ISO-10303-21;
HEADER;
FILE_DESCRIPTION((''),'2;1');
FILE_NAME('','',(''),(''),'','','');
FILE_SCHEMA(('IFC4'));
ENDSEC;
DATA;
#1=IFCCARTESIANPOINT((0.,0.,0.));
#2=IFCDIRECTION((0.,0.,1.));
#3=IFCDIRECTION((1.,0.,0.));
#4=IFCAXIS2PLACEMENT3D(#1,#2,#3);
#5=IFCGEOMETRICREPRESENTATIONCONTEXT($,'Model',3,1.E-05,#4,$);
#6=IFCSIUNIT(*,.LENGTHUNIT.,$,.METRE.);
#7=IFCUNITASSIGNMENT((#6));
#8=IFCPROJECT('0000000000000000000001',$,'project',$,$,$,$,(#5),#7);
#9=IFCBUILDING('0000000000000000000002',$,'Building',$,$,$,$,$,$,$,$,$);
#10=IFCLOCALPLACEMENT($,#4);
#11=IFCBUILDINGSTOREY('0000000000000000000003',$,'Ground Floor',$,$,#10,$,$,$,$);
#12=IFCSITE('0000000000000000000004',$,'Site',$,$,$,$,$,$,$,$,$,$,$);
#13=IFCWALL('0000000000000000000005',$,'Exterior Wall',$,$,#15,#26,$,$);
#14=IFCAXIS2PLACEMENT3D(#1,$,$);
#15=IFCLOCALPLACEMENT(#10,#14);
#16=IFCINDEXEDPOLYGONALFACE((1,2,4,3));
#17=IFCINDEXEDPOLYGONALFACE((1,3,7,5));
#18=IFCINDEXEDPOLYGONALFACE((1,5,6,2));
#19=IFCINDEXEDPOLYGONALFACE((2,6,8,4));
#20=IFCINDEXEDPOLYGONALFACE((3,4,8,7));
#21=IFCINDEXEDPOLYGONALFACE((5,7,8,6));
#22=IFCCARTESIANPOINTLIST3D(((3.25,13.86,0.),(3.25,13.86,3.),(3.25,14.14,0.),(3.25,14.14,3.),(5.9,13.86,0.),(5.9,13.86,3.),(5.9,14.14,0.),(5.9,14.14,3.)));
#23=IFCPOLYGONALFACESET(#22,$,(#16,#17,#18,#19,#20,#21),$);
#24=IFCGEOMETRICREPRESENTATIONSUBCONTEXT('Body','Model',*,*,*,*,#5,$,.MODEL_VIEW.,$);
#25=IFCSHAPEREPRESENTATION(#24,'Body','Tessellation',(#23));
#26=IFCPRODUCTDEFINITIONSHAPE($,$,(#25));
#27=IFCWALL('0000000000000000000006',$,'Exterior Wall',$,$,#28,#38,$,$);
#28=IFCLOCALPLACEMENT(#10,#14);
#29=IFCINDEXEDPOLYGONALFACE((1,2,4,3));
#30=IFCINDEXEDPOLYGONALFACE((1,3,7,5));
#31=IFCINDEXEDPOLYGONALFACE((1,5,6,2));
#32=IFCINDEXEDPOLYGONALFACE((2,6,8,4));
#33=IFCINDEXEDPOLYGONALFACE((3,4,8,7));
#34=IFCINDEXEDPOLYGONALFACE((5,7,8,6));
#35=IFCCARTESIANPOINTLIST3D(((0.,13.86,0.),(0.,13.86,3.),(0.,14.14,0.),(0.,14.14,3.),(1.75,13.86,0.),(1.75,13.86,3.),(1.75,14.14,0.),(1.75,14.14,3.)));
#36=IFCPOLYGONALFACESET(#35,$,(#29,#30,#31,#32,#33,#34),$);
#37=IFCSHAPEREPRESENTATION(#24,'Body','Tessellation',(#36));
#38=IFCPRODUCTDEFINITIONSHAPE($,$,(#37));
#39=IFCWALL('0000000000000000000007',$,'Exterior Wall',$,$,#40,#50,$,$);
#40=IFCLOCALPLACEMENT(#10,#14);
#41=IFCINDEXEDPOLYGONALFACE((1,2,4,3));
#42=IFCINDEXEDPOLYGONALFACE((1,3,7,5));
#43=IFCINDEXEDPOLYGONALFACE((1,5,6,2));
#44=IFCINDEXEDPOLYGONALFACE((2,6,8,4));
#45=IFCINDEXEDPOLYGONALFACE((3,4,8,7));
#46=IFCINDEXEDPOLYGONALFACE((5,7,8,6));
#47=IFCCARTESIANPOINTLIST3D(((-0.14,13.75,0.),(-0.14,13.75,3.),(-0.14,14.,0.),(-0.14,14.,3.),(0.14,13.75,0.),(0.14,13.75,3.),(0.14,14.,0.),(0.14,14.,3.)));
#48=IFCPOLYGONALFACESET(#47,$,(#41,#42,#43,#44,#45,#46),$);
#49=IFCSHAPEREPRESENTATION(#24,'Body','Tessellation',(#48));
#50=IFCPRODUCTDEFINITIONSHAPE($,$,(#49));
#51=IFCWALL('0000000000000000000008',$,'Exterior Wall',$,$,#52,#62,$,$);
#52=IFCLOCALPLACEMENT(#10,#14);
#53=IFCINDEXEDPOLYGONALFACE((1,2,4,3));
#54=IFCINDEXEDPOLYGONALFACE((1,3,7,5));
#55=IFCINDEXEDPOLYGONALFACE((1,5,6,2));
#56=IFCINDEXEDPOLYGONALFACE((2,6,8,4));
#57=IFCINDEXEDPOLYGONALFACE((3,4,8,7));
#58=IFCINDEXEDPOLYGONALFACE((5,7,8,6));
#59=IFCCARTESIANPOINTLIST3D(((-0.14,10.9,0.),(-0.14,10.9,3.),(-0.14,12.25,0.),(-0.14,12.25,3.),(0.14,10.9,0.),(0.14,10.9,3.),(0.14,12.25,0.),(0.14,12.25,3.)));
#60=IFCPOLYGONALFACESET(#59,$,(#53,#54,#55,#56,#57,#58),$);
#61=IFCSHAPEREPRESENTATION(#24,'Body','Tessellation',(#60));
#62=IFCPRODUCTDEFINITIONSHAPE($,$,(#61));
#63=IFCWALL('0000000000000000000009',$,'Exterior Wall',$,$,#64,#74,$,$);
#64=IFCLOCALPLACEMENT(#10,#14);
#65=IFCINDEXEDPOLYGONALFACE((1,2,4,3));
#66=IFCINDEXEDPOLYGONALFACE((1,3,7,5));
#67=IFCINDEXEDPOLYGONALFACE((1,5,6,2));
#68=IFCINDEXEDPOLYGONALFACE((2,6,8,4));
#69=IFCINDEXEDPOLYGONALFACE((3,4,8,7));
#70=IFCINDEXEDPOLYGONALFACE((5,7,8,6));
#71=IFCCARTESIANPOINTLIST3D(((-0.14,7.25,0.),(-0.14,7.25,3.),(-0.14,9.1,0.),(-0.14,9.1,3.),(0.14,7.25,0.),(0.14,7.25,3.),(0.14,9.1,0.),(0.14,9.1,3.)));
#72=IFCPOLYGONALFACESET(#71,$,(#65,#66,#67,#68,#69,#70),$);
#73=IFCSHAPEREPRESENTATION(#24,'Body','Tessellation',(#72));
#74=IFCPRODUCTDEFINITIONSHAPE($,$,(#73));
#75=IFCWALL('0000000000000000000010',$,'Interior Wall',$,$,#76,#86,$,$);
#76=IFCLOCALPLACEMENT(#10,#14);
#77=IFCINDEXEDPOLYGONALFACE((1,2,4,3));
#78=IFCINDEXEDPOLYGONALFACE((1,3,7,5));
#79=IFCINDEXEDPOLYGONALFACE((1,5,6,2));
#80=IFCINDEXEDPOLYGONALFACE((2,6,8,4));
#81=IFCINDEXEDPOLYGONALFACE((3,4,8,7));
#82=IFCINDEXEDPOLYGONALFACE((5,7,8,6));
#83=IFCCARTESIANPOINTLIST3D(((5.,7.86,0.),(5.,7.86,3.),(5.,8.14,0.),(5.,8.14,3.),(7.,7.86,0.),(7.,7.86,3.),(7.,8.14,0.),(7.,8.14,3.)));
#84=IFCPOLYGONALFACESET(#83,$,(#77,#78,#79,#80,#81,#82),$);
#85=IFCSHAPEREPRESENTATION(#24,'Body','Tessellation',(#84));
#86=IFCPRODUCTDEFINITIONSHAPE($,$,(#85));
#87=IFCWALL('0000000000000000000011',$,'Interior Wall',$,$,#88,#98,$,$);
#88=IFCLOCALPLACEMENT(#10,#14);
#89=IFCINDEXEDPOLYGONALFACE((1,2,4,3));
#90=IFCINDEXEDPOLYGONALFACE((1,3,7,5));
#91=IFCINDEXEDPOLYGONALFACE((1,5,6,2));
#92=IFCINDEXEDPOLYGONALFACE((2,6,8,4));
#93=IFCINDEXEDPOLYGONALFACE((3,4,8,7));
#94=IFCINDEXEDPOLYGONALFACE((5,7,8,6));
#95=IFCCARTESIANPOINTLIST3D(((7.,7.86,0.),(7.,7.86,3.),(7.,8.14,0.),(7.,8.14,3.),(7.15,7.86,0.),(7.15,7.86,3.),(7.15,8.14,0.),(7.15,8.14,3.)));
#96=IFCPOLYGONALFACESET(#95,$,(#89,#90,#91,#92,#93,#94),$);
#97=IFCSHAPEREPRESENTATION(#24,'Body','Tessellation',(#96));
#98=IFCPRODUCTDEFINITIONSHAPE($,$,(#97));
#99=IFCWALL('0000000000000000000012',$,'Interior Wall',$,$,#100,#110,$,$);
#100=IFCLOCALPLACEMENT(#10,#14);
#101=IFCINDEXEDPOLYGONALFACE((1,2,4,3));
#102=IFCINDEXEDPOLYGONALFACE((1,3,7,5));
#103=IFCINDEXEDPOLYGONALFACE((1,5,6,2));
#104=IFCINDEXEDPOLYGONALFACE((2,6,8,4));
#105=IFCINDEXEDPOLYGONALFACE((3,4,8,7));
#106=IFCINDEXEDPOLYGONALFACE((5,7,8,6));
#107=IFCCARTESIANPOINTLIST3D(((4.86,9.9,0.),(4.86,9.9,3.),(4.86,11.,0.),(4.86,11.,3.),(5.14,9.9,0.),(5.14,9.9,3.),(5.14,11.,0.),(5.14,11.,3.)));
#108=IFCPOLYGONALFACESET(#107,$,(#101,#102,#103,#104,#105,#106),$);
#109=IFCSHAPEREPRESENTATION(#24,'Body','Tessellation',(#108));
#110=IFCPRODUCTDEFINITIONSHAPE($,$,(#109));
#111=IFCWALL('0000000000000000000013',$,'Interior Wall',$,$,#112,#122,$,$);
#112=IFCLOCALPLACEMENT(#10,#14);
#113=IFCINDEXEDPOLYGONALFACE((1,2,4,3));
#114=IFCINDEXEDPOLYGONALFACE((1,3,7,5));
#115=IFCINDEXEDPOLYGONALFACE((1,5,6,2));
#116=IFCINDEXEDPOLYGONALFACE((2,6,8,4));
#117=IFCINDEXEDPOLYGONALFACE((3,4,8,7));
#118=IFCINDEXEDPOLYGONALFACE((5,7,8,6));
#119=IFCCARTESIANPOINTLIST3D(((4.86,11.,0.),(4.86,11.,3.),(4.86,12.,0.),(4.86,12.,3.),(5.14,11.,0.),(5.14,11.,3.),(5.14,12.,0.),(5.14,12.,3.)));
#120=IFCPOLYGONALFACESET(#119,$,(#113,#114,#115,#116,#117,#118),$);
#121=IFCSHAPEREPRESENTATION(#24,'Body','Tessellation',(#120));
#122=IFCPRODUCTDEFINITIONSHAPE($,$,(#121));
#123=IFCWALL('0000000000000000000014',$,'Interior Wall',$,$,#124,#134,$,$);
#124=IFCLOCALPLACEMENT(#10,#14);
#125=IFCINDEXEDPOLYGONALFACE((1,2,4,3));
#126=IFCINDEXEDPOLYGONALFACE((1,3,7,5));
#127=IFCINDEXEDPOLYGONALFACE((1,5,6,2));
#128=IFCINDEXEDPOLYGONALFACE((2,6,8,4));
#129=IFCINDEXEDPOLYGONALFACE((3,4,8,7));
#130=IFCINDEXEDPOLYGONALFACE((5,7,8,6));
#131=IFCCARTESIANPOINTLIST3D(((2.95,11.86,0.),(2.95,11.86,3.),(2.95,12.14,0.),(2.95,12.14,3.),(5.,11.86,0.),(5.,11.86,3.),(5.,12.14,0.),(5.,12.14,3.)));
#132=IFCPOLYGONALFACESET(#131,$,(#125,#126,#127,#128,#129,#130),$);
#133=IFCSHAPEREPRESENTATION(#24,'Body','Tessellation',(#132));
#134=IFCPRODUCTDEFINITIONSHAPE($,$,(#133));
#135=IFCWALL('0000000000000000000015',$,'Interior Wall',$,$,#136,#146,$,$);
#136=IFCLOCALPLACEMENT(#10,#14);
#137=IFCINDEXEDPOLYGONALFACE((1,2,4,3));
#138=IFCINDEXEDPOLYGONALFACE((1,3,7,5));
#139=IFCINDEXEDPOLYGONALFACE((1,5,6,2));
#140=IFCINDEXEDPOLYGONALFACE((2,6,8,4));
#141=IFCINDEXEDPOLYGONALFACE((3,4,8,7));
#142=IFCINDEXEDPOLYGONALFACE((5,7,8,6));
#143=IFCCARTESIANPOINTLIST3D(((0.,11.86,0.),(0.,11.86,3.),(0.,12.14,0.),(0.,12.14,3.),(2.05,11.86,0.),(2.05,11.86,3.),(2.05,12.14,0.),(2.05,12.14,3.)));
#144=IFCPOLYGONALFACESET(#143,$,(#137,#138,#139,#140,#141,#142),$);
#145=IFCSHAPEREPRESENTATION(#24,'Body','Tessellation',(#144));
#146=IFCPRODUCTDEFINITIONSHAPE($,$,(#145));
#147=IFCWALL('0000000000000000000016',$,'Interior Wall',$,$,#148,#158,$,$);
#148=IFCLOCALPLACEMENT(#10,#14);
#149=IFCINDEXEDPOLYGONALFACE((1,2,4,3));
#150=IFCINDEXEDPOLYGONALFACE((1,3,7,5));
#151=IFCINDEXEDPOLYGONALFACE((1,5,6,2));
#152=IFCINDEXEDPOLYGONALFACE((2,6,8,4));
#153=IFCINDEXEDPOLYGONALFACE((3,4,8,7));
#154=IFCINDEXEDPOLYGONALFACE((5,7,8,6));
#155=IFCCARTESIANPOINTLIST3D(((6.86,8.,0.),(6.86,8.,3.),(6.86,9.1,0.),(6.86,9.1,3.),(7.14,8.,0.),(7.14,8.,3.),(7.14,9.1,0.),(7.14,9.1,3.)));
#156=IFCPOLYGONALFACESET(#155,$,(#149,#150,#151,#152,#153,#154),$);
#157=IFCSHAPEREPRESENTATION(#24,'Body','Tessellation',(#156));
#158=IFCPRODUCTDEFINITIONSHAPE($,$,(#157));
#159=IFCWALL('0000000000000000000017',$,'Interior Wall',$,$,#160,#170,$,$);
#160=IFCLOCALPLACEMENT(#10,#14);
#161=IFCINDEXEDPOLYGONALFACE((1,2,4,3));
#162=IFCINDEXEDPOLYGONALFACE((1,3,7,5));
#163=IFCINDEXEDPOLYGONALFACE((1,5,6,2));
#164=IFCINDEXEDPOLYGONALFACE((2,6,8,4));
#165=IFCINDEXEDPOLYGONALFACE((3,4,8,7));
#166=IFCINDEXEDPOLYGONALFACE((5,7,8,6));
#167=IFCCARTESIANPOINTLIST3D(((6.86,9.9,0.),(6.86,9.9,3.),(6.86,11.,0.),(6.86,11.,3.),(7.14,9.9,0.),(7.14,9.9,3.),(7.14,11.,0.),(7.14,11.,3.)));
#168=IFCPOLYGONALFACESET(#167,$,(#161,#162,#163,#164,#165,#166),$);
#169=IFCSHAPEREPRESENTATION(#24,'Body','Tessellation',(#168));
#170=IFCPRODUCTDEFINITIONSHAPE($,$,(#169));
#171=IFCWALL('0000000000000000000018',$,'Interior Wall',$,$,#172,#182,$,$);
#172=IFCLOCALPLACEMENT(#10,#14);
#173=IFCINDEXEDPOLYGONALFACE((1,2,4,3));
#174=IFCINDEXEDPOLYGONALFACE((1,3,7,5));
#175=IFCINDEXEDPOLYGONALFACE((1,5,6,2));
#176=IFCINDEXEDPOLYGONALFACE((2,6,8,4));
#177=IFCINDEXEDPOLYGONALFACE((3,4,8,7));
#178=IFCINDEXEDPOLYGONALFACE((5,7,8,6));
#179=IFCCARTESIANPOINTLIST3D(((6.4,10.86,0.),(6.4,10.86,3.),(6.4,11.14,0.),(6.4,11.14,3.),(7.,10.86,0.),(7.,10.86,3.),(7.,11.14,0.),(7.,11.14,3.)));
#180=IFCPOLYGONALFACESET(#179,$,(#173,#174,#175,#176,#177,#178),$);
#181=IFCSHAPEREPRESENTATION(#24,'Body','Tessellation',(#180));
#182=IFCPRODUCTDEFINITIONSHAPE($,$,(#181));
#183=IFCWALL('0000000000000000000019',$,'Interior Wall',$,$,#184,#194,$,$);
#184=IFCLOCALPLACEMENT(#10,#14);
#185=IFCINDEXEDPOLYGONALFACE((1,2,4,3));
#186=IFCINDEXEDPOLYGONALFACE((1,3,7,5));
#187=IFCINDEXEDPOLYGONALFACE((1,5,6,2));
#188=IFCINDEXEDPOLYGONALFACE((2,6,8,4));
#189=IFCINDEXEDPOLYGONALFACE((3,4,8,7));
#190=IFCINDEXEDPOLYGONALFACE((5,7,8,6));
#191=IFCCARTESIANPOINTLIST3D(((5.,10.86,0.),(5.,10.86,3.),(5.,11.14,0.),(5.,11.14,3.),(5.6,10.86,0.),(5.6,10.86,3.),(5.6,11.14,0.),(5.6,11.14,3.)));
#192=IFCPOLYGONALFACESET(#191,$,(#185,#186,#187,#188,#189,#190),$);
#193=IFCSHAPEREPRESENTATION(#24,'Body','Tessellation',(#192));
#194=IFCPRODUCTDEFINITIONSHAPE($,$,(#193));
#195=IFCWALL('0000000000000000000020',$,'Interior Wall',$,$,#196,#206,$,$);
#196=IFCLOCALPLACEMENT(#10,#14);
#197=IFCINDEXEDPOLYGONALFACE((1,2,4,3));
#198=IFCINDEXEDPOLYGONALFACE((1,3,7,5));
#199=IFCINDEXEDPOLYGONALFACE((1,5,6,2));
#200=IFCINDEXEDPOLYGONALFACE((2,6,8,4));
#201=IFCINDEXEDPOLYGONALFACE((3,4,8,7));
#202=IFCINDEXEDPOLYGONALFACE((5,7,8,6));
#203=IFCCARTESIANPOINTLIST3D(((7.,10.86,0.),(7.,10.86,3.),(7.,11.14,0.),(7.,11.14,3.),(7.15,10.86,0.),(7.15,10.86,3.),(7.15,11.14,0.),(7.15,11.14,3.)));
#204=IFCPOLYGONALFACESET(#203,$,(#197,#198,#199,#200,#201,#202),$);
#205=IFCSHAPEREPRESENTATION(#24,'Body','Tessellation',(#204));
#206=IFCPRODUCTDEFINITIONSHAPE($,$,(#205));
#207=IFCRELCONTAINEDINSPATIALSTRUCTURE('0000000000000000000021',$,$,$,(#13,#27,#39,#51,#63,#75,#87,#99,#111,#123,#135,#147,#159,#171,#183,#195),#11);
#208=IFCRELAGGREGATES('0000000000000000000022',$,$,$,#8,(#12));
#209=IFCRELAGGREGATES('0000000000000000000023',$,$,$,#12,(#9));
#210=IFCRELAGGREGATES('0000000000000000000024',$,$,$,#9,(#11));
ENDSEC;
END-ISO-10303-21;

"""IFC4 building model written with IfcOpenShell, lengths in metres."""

from ifc_helpers import new_model, si_unit, frame, origin_with_axes, place, context, subcontext, project, spatial, indexed_curve, outline, extrude, element, save


model = new_model("IFC4")

# Units and contexts
model_context = context("Model", 3, precision=1e-05, world=origin_with_axes())
body_context = subcontext(model_context, "Body", "Model", "MODEL_VIEW")
ifc_project = project(units=[si_unit("LENGTHUNIT", "METRE")], contexts=[model_context])

# Site, building, storey
site = spatial("IfcSite", under=ifc_project, Name="Site")
building = spatial("IfcBuilding", under=site, Name="Building")
storey_placement = place(None, origin_with_axes())
storey = spatial("IfcBuildingStorey", under=building, at=storey_placement, Name="Ground Floor")

# Walls
wall_1_placement = place(storey_placement, frame((5.9, 14.0, 0.0), z_axis=(0.0, 0.0, 1.0), x_axis=(-1.0, 0.0, 0.0)))
element("IfcWall", 1, at=wall_1_placement, inside=storey, Name="Exterior Wall", context=body_context, shape_type="SweptSolid", body=[
    extrude(outline(indexed_curve([(0.0, 0.0), (0.0, 0.28), (2.65, 0.28), (2.65, 0.0), (0.0, 0.0)], self_intersect=False)), frame((0.0, -0.14, 0.0), z_axis=(0.0, 0.0, 1.0), x_axis=(1.0, 0.0, 0.0)), (0.0, 0.0, 1.0), 3.0),
])
wall_2_placement = place(storey_placement, frame((1.75, 14.0, 0.0), z_axis=(0.0, 0.0, 1.0), x_axis=(-1.0, 0.0, 0.0)))
element("IfcWall", 2, at=wall_2_placement, inside=storey, Name="Exterior Wall", context=body_context, shape_type="SweptSolid", body=[
    extrude(outline(indexed_curve([(0.0, 0.0), (0.0, 0.28), (1.75, 0.28), (1.75, 0.0), (0.0, 0.0)], self_intersect=False)), frame((0.0, -0.14, 0.0), z_axis=(0.0, 0.0, 1.0), x_axis=(1.0, 0.0, 0.0)), (0.0, 0.0, 1.0), 3.0),
])
wall_3_placement = place(storey_placement, frame((0.0, 14.0, 0.0), z_axis=(0.0, 0.0, 1.0), x_axis=(0.0, -1.0, 0.0)))
element("IfcWall", 3, at=wall_3_placement, inside=storey, Name="Exterior Wall", context=body_context, shape_type="SweptSolid", body=[
    extrude(outline(indexed_curve([(0.0, 0.0), (0.0, 0.28), (0.25, 0.28), (0.25, 0.0), (0.0, 0.0)], self_intersect=False)), frame((0.0, -0.14, 0.0), z_axis=(0.0, 0.0, 1.0), x_axis=(1.0, 0.0, 0.0)), (0.0, 0.0, 1.0), 3.0),
])
wall_4_placement = place(storey_placement, frame((0.0, 12.25, 0.0), z_axis=(0.0, 0.0, 1.0), x_axis=(0.0, -1.0, 0.0)))
element("IfcWall", 4, at=wall_4_placement, inside=storey, Name="Exterior Wall", context=body_context, shape_type="SweptSolid", body=[
    extrude(outline(indexed_curve([(0.0, 0.0), (0.0, 0.28), (1.35, 0.28), (1.35, 0.0), (0.0, 0.0)], self_intersect=False)), frame((0.0, -0.14, 0.0), z_axis=(0.0, 0.0, 1.0), x_axis=(1.0, 0.0, 0.0)), (0.0, 0.0, 1.0), 3.0),
])
wall_5_placement = place(storey_placement, frame((0.0, 9.1, 0.0), z_axis=(0.0, 0.0, 1.0), x_axis=(0.0, -1.0, 0.0)))
element("IfcWall", 5, at=wall_5_placement, inside=storey, Name="Exterior Wall", context=body_context, shape_type="SweptSolid", body=[
    extrude(outline(indexed_curve([(0.0, 0.0), (0.0, 0.28), (1.85, 0.28), (1.85, 0.0), (0.0, 0.0)], self_intersect=False)), frame((0.0, -0.14, 0.0), z_axis=(0.0, 0.0, 1.0), x_axis=(1.0, 0.0, 0.0)), (0.0, 0.0, 1.0), 3.0),
])
wall_6_placement = place(storey_placement, frame((7.0, 8.0, 0.0), z_axis=(0.0, 0.0, 1.0), x_axis=(-1.0, 0.0, 0.0)))
element("IfcWall", 6, at=wall_6_placement, inside=storey, Name="Interior Wall", context=body_context, shape_type="SweptSolid", body=[
    extrude(outline(indexed_curve([(0.0, 0.0), (0.0, 0.28), (2.0, 0.28), (2.0, 0.0), (0.0, 0.0)], self_intersect=False)), frame((0.0, -0.14, 0.0), z_axis=(0.0, 0.0, 1.0), x_axis=(1.0, 0.0, 0.0)), (0.0, 0.0, 1.0), 3.0),
])
wall_7_placement = place(storey_placement, frame((7.15, 8.0, 0.0), z_axis=(0.0, 0.0, 1.0), x_axis=(-1.0, 0.0, 0.0)))
element("IfcWall", 7, at=wall_7_placement, inside=storey, Name="Interior Wall", context=body_context, shape_type="SweptSolid", body=[
    extrude(outline(indexed_curve([(0.0, 0.0), (0.0, 0.28), (0.15, 0.28), (0.15, 0.0), (0.0, 0.0)], self_intersect=False)), frame((0.0, -0.14, 0.0), z_axis=(0.0, 0.0, 1.0), x_axis=(1.0, 0.0, 0.0)), (0.0, 0.0, 1.0), 3.0),
])
wall_8_placement = place(storey_placement, frame((5.0, 9.9, 0.0), z_axis=(0.0, 0.0, 1.0), x_axis=(0.0, 1.0, 0.0)))
element("IfcWall", 8, at=wall_8_placement, inside=storey, Name="Interior Wall", context=body_context, shape_type="SweptSolid", body=[
    extrude(outline(indexed_curve([(0.0, 0.0), (0.0, 0.28), (1.1, 0.28), (1.1, 0.0), (0.0, 0.0)], self_intersect=False)), frame((0.0, -0.14, 0.0), z_axis=(0.0, 0.0, 1.0), x_axis=(1.0, 0.0, 0.0)), (0.0, 0.0, 1.0), 3.0),
])
wall_9_placement = place(storey_placement, frame((5.0, 11.0, 0.0), z_axis=(0.0, 0.0, 1.0), x_axis=(0.0, 1.0, 0.0)))
element("IfcWall", 9, at=wall_9_placement, inside=storey, Name="Interior Wall", context=body_context, shape_type="SweptSolid", body=[
    extrude(outline(indexed_curve([(0.0, 0.0), (0.0, 0.28), (1.0, 0.28), (1.0, 0.0), (0.0, 0.0)], self_intersect=False)), frame((0.0, -0.14, 0.0), z_axis=(0.0, 0.0, 1.0), x_axis=(1.0, 0.0, 0.0)), (0.0, 0.0, 1.0), 3.0),
])
for number, where, z_axis, x_axis, name in (
    (10, (5.0, 12.0, 0.0), (0.0, 0.0, 1.0), (-1.0, 0.0, 0.0), "Interior Wall"),
    (11, (2.05, 12.0, 0.0), (0.0, 0.0, 1.0), (-1.0, 0.0, 0.0), "Interior Wall"),
):
    element("IfcWall", number, at=place(storey_placement, frame(where, z_axis=z_axis, x_axis=x_axis)), inside=storey, Name=name, context=body_context, shape_type="SweptSolid", body=[
        extrude(outline(indexed_curve([(0.0, 0.0), (0.0, 0.28), (2.05, 0.28), (2.05, 0.0), (0.0, 0.0)], self_intersect=False)), frame((0.0, -0.14, 0.0), z_axis=(0.0, 0.0, 1.0), x_axis=(1.0, 0.0, 0.0)), (0.0, 0.0, 1.0), 3.0),
    ])
for number, where, z_axis, x_axis, name in (
    (12, (7.0, 8.0, 0.0), (0.0, 0.0, 1.0), (0.0, 1.0, 0.0), "Interior Wall"),
    (13, (7.0, 9.9, 0.0), (0.0, 0.0, 1.0), (0.0, 1.0, 0.0), "Interior Wall"),
):
    element("IfcWall", number, at=place(storey_placement, frame(where, z_axis=z_axis, x_axis=x_axis)), inside=storey, Name=name, context=body_context, shape_type="SweptSolid", body=[
        extrude(outline(indexed_curve([(0.0, 0.0), (0.0, 0.28), (1.1, 0.28), (1.1, 0.0), (0.0, 0.0)], self_intersect=False)), frame((0.0, -0.14, 0.0), z_axis=(0.0, 0.0, 1.0), x_axis=(1.0, 0.0, 0.0)), (0.0, 0.0, 1.0), 3.0),
    ])
for number, where, z_axis, x_axis, name in (
    (14, (7.0, 11.0, 0.0), (0.0, 0.0, 1.0), (-1.0, 0.0, 0.0), "Interior Wall"),
    (15, (5.6, 11.0, 0.0), (0.0, 0.0, 1.0), (-1.0, 0.0, 0.0), "Interior Wall"),
):
    element("IfcWall", number, at=place(storey_placement, frame(where, z_axis=z_axis, x_axis=x_axis)), inside=storey, Name=name, context=body_context, shape_type="SweptSolid", body=[
        extrude(outline(indexed_curve([(0.0, 0.0), (0.0, 0.28), (0.6, 0.28), (0.6, 0.0), (0.0, 0.0)], self_intersect=False)), frame((0.0, -0.14, 0.0), z_axis=(0.0, 0.0, 1.0), x_axis=(1.0, 0.0, 0.0)), (0.0, 0.0, 1.0), 3.0),
    ])
wall_10_placement = place(storey_placement, frame((7.15, 11.0, 0.0), z_axis=(0.0, 0.0, 1.0), x_axis=(-1.0, 0.0, 0.0)))
element("IfcWall", 16, at=wall_10_placement, inside=storey, Name="Interior Wall", context=body_context, shape_type="SweptSolid", body=[
    extrude(outline(indexed_curve([(0.0, 0.0), (0.0, 0.28), (0.15, 0.28), (0.15, 0.0), (0.0, 0.0)], self_intersect=False)), frame((0.0, -0.14, 0.0), z_axis=(0.0, 0.0, 1.0), x_axis=(1.0, 0.0, 0.0)), (0.0, 0.0, 1.0), 3.0),
])

save(model, "model.ifc")
